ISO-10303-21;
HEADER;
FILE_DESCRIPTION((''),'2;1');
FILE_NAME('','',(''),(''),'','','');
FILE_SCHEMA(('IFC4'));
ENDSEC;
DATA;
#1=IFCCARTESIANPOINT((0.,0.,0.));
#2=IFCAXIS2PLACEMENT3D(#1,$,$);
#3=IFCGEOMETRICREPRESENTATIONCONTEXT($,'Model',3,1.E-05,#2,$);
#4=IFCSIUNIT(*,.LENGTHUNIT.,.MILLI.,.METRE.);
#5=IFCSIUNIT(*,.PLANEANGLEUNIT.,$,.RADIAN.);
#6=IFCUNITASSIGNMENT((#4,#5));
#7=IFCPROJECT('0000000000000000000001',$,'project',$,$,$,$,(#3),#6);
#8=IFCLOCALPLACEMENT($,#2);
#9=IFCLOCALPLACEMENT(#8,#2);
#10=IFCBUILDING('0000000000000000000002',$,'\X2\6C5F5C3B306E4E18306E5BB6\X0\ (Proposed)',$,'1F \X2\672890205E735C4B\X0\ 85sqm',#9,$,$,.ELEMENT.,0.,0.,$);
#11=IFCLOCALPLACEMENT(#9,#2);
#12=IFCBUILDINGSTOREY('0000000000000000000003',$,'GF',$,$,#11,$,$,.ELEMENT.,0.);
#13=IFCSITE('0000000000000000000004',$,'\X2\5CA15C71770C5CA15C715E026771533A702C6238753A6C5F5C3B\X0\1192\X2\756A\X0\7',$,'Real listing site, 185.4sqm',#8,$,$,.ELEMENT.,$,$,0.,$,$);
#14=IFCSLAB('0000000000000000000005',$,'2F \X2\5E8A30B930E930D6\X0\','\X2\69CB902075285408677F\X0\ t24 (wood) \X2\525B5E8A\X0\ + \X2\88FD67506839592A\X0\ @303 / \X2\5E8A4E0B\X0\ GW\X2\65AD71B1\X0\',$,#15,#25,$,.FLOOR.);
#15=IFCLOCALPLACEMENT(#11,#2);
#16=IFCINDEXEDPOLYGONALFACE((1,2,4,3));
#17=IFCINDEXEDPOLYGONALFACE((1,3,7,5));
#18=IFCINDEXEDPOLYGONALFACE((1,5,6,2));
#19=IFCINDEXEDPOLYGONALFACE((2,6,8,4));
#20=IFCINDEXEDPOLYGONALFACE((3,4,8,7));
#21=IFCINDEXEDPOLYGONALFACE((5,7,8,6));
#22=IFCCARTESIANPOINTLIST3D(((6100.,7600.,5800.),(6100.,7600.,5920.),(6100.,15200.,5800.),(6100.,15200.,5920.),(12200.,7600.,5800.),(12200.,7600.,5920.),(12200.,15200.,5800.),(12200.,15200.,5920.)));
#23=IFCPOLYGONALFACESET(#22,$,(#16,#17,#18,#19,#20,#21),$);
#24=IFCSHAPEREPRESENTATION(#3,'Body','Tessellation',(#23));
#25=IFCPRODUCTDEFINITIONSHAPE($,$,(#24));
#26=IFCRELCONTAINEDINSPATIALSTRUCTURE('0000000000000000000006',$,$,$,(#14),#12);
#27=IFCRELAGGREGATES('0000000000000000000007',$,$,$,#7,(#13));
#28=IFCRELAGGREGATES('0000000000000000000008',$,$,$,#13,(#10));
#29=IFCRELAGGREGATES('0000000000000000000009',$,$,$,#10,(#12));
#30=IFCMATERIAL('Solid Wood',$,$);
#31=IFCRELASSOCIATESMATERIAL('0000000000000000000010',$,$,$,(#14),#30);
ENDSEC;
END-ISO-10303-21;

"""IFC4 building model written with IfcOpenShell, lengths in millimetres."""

from ifc_helpers import new_model, si_unit, frame, frame_2d, origin, place, context, project, spatial, rectangle, extrude, material, element, save


model = new_model("IFC4")

# Units and contexts
model_context = context("Model", 3, precision=1e-05, world=origin())
ifc_project = project(units=[si_unit("LENGTHUNIT", "METRE", prefix="MILLI"), si_unit("PLANEANGLEUNIT", "RADIAN")], contexts=[model_context])

# Site, building, storey
site_placement = place(None, origin())
site = spatial("IfcSite", under=ifc_project, at=site_placement, Name="岡山県岡山市東区瀬戸町江尻1192番7", ObjectType="Real listing site, 185.4sqm", CompositionType="ELEMENT", RefElevation=0.0)
building_placement = place(site_placement, origin())
building = spatial("IfcBuilding", under=site, at=building_placement, Name="江尻の丘の家 (Proposed)", ObjectType="1F 木造平屋 85sqm", CompositionType="ELEMENT", ElevationOfRefHeight=0.0, ElevationOfTerrain=0.0)
storey_placement = place(building_placement, origin())
storey = spatial("IfcBuildingStorey", under=building, at=storey_placement, Name="GF", CompositionType="ELEMENT", Elevation=0.0)

# Slab
ifc_material_1 = material(Name="Solid Wood")
slab_placement = place(storey_placement, frame((3050.0, 3800.0, 2900.0)))
element("IfcSlab", 1, at=slab_placement, inside=storey, material=ifc_material_1, Name="2F 床スラブ", Description="構造用合板 t24 (wood) 剛床 + 製材根太 @303 / 床下 GW断熱", PredefinedType="FLOOR", context=model_context, shape_type="SweptSolid", body=[
    extrude(rectangle(XDim=6100.0, YDim=7600.0, at=frame_2d((3050.0, 3800.0))), frame((3050.0, 3800.0, 2900.0)), (0.0, 0.0, 1.0), 120.0),
])

save(model, "model.ifc")
